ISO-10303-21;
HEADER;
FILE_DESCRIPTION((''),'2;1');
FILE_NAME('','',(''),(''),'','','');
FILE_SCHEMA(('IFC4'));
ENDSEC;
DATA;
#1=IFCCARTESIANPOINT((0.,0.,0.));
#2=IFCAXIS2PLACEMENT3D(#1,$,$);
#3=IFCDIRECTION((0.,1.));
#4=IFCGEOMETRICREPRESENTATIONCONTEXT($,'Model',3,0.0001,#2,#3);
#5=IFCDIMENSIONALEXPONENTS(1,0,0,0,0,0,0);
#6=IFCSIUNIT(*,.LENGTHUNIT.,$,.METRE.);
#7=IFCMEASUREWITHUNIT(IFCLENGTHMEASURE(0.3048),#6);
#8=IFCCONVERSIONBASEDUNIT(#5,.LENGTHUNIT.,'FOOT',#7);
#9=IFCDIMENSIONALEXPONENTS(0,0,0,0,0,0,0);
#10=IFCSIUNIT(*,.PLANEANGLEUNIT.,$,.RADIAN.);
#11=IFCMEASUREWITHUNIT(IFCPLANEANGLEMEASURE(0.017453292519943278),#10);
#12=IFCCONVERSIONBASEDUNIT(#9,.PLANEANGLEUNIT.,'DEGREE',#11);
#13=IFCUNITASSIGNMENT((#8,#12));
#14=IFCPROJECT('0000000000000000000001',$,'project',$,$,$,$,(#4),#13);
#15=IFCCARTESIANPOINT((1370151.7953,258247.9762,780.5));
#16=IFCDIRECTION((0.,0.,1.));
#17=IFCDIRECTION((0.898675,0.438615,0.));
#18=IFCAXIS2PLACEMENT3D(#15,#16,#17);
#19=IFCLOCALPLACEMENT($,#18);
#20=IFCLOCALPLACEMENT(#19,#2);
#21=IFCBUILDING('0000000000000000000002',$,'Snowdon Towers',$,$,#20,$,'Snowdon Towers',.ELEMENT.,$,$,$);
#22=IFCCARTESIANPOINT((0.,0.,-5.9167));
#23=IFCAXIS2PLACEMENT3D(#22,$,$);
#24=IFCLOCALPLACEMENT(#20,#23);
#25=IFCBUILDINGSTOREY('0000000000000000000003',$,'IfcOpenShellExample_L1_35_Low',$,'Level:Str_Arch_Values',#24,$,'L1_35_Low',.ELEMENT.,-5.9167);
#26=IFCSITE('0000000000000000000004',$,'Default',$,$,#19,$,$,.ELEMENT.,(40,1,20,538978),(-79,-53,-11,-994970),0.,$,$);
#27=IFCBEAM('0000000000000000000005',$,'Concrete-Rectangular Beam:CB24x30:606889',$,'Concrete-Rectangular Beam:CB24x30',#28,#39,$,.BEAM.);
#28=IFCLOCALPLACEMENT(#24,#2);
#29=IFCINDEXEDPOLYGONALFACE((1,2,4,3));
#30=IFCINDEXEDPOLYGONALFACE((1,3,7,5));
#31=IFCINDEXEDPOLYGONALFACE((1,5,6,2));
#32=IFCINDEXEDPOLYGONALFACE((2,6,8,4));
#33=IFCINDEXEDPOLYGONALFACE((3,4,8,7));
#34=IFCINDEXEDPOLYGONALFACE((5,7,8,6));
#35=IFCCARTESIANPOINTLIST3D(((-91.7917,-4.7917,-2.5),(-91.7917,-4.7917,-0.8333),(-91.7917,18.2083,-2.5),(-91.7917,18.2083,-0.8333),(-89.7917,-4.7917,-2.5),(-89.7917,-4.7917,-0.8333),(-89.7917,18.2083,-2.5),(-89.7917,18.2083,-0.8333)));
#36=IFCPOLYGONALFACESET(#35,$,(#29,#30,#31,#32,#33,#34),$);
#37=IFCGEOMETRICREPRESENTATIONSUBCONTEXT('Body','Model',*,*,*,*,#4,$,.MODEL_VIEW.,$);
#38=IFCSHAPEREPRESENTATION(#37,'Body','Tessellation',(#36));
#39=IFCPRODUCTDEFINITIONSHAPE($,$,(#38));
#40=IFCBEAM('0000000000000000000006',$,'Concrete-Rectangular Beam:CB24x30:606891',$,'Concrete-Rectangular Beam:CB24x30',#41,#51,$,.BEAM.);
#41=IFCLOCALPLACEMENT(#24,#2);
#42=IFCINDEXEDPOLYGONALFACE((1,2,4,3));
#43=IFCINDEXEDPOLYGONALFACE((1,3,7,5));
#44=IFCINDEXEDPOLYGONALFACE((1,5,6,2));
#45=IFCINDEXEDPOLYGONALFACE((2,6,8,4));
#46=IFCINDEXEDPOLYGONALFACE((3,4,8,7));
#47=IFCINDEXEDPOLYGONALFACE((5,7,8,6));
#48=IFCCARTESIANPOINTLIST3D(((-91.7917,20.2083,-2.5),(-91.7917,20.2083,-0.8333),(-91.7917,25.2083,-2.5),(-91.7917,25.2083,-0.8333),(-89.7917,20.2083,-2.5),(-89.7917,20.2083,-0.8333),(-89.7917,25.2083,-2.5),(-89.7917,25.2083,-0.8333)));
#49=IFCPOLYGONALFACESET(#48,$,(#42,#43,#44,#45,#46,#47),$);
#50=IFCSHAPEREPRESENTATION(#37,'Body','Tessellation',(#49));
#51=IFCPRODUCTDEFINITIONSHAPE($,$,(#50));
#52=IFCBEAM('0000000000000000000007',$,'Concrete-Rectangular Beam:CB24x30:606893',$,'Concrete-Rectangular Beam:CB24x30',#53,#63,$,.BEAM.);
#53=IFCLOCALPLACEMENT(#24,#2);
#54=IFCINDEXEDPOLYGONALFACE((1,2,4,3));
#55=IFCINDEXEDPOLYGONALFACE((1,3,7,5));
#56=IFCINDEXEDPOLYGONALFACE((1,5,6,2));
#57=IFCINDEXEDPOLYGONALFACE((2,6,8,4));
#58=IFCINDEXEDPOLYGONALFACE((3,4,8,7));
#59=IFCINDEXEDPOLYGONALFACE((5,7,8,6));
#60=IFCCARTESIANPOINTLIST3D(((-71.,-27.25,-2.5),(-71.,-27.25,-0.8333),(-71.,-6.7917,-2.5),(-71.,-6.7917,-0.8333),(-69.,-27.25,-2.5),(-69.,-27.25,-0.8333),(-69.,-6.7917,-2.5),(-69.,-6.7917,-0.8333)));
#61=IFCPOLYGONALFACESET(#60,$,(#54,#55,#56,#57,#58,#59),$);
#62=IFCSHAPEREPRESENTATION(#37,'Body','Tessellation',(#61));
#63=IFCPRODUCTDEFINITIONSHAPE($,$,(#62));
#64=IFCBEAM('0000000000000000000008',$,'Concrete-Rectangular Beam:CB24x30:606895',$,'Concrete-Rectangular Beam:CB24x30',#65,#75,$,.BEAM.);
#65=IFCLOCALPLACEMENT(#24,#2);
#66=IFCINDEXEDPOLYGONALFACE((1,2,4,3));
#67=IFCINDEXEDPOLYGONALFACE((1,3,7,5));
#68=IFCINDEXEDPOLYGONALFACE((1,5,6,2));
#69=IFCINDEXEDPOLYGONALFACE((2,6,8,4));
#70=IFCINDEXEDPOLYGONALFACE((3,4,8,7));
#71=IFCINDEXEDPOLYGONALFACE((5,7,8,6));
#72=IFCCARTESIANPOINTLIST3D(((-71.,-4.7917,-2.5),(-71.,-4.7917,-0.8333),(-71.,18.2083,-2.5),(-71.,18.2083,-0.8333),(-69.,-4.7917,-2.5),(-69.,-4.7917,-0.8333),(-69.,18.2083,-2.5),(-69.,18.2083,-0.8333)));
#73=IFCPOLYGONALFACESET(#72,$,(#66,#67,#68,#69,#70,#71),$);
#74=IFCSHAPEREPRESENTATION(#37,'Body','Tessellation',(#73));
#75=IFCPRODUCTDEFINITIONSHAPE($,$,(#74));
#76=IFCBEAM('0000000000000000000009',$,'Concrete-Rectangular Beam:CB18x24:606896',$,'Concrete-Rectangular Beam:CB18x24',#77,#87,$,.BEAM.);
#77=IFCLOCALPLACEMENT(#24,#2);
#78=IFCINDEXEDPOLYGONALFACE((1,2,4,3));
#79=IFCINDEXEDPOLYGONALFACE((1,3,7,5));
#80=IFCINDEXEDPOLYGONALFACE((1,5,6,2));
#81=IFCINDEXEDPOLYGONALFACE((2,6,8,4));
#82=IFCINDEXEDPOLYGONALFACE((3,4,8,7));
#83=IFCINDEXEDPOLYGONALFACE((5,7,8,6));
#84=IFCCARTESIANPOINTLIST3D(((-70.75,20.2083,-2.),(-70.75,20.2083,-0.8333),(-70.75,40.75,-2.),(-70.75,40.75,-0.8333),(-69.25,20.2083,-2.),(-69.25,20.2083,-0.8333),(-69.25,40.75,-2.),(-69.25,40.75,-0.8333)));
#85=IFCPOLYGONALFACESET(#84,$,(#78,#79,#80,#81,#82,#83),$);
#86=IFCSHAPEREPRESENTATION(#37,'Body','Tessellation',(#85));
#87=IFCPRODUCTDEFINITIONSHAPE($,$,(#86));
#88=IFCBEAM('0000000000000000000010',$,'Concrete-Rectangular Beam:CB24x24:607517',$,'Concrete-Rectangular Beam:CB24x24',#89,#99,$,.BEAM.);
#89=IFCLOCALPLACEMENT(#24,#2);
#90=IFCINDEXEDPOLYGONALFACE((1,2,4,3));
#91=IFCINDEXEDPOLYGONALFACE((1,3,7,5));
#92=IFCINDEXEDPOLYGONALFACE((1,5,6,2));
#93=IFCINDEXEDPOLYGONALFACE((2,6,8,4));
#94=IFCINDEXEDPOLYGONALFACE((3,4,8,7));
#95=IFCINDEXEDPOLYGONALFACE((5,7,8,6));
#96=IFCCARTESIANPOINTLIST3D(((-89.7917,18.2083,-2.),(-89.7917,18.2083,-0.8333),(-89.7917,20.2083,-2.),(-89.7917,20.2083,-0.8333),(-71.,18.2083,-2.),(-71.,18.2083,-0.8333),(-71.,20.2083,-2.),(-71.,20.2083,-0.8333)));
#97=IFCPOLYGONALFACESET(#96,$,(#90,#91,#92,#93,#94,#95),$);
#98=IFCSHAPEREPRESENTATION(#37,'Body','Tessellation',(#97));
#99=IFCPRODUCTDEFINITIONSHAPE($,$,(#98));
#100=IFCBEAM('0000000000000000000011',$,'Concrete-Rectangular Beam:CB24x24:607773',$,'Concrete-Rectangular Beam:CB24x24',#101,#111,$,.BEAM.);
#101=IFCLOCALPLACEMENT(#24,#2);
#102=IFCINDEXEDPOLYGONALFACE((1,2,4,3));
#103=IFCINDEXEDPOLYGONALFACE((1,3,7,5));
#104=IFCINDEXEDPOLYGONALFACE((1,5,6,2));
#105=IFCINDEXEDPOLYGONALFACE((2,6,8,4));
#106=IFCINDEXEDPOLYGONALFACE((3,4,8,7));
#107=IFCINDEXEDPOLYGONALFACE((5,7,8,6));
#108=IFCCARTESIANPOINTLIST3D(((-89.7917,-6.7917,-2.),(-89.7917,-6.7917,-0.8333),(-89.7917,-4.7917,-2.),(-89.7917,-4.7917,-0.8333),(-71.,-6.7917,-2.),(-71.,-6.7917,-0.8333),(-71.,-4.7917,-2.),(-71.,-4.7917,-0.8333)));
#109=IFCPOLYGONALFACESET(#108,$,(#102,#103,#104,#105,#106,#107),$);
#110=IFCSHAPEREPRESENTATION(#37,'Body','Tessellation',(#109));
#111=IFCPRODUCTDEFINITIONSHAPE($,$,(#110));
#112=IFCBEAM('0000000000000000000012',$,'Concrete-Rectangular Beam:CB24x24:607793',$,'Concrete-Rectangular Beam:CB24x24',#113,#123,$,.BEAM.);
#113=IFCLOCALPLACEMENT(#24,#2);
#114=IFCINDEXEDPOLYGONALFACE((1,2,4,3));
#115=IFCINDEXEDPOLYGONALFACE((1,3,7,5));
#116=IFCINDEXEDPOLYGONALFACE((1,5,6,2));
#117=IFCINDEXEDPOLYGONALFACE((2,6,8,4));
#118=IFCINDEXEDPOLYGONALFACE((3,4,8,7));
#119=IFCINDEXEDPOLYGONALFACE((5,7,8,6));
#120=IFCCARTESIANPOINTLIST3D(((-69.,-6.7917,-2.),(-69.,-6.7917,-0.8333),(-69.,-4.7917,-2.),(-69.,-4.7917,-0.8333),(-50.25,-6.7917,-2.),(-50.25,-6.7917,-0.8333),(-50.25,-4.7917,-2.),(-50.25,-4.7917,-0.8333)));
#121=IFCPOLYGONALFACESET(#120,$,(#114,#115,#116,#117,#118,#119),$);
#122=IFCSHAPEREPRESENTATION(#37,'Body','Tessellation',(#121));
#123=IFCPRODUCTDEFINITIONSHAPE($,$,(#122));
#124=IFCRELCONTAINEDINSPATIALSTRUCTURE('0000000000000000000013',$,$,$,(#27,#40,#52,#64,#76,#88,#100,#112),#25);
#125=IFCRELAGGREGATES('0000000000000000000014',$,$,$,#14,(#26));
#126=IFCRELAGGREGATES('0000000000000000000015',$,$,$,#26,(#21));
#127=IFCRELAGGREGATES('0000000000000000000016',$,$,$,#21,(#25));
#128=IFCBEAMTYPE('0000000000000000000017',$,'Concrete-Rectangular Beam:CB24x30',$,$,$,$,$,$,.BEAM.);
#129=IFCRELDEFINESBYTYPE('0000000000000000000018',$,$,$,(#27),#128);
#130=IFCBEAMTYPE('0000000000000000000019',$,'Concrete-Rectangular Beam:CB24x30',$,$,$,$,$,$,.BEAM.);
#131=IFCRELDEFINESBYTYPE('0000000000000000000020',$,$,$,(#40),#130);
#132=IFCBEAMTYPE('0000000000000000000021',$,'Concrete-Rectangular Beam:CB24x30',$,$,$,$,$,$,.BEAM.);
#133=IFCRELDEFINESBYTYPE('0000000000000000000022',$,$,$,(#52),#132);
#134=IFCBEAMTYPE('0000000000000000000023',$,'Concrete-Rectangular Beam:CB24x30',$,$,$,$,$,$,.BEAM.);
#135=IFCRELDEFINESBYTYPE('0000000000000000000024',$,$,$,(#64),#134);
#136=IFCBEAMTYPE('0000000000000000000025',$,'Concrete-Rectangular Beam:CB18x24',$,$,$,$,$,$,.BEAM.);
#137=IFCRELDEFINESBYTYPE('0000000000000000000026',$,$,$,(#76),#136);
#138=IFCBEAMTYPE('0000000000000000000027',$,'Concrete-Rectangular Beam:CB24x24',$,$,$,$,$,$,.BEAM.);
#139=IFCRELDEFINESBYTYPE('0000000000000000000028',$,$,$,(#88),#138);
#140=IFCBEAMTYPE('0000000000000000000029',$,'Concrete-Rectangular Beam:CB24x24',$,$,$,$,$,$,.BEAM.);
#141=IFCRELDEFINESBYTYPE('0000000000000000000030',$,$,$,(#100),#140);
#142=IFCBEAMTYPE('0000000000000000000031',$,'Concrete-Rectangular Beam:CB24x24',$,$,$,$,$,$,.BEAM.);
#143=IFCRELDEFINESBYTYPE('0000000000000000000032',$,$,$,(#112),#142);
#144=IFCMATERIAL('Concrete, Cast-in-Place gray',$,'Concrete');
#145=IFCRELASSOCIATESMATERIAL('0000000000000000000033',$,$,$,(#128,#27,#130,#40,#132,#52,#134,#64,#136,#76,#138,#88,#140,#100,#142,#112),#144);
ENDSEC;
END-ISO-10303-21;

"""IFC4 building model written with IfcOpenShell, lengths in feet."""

from ifc_helpers import new_model, entity, si_unit, converted_unit, direction, frame, origin, place, context, subcontext, project, spatial, indexed_curve, outline, extrude, source, transform, mapped, material, type_object, type_shapes, element, save


model = new_model("IFC4")

# Units and contexts
model_context = context("Model", 3, precision=0.0001, world=origin(), true_north=direction((0.0, 1.0)))
body_context = subcontext(model_context, "Body", "Model", "MODEL_VIEW")
ifc_project = project(units=[converted_unit("LENGTHUNIT", "FOOT", entity("IfcLengthMeasure", 0.3048), si_unit("LENGTHUNIT", "METRE"), dimensions=[1, 0, 0, 0, 0, 0, 0]), converted_unit("PLANEANGLEUNIT", "DEGREE", entity("IfcPlaneAngleMeasure", 0.017453292519943278), si_unit("PLANEANGLEUNIT", "RADIAN"), dimensions=[0, 0, 0, 0, 0, 0, 0])], contexts=[model_context])

# Site, building, storey
site_placement = place(None, frame((1370151.7953, 258247.9762, 780.5), z_axis=(0.0, 0.0, 1.0), x_axis=(0.898675, 0.438615, 0.0)))
site = spatial("IfcSite", under=ifc_project, at=site_placement, Name="Default", CompositionType="ELEMENT", RefLatitude=(40, 1, 20, 538978), RefLongitude=(-79, -53, -11, -994970), RefElevation=0.0)
building_placement = place(site_placement, origin())
building = spatial("IfcBuilding", under=site, at=building_placement, Name="Snowdon Towers", LongName="Snowdon Towers", CompositionType="ELEMENT")
storey_placement = place(building_placement, frame((0.0, 0.0, -5.9167)))
storey = spatial("IfcBuildingStorey", under=building, at=storey_placement, Name="IfcOpenShellExample_L1_35_Low", ObjectType="Level:Str_Arch_Values", LongName="L1_35_Low", CompositionType="ELEMENT", Elevation=-5.9167)

# Beams
ifc_material_1 = material(Name="Concrete, Cast-in-Place gray", Category="Concrete")
beam_type_1 = type_object("IfcBeamType", Name="Concrete-Rectangular Beam:CB24x30", PredefinedType="BEAM", material=ifc_material_1)
shared_shape_1 = source(origin(), body_context, "Body", "SweptSolid", [
    extrude(outline(indexed_curve([(-1.0, -0.8333), (1.0, -0.8333), (1.0, 0.8333), (-1.0, 0.8333), (-1.0, -0.8333)], self_intersect=False)), frame((-90.7917, -4.7917, -7.5833), z_axis=(0.0, 1.0, 0.0), x_axis=(-1.0, 0.0, 0.0)), (0.0, 0.0, 1.0), 23.0),
])
type_shapes(beam_type_1, [shared_shape_1])
beam_1_placement = place(storey_placement, frame((0.0, 0.0, 5.9167)))
element("IfcBeam", 1, at=beam_1_placement, inside=storey, type_object=beam_type_1, material=ifc_material_1, Name="Concrete-Rectangular Beam:CB24x30:606889", ObjectType="Concrete-Rectangular Beam:CB24x30", PredefinedType="BEAM", context=body_context, shape_type="MappedRepresentation", body=[
    mapped(shared_shape_1, transform((0.0, 0.0, 0.0), scale=1.0)),
])
beam_type_2 = type_object("IfcBeamType", Name="Concrete-Rectangular Beam:CB24x30", PredefinedType="BEAM", material=ifc_material_1)
shared_shape_2 = source(origin(), body_context, "Body", "SweptSolid", [
    extrude(outline(indexed_curve([(-1.0, -0.8333), (1.0, -0.8333), (1.0, 0.8333), (-1.0, 0.8333), (-1.0, -0.8333)], self_intersect=False)), frame((-90.7917, 20.2083, -7.5833), z_axis=(0.0, 1.0, 0.0), x_axis=(-1.0, 0.0, 0.0)), (0.0, 0.0, 1.0), 5.0),
])
type_shapes(beam_type_2, [shared_shape_2])
beam_2_placement = place(storey_placement, frame((0.0, 0.0, 5.9167)))
element("IfcBeam", 2, at=beam_2_placement, inside=storey, type_object=beam_type_2, material=ifc_material_1, Name="Concrete-Rectangular Beam:CB24x30:606891", ObjectType="Concrete-Rectangular Beam:CB24x30", PredefinedType="BEAM", context=body_context, shape_type="MappedRepresentation", body=[
    mapped(shared_shape_2, transform((0.0, 0.0, 0.0), scale=1.0)),
])
beam_type_3 = type_object("IfcBeamType", Name="Concrete-Rectangular Beam:CB24x30", PredefinedType="BEAM", material=ifc_material_1)
shared_shape_3 = source(origin(), body_context, "Body", "SweptSolid", [
    extrude(outline(indexed_curve([(-1.0, -0.8333), (1.0, -0.8333), (1.0, 0.8333), (-1.0, 0.8333), (-1.0, -0.8333)], self_intersect=False)), frame((-70.0, -27.25, -7.5833), z_axis=(0.0, 1.0, 0.0), x_axis=(-1.0, 0.0, 0.0)), (0.0, 0.0, 1.0), 20.4583),
])
type_shapes(beam_type_3, [shared_shape_3])
beam_3_placement = place(storey_placement, frame((0.0, 0.0, 5.9167)))
element("IfcBeam", 3, at=beam_3_placement, inside=storey, type_object=beam_type_3, material=ifc_material_1, Name="Concrete-Rectangular Beam:CB24x30:606893", ObjectType="Concrete-Rectangular Beam:CB24x30", PredefinedType="BEAM", context=body_context, shape_type="MappedRepresentation", body=[
    mapped(shared_shape_3, transform((0.0, 0.0, 0.0), scale=1.0)),
])
beam_type_4 = type_object("IfcBeamType", Name="Concrete-Rectangular Beam:CB24x30", PredefinedType="BEAM", material=ifc_material_1)
shared_shape_4 = source(origin(), body_context, "Body", "SweptSolid", [
    extrude(outline(indexed_curve([(-1.0, -0.8333), (1.0, -0.8333), (1.0, 0.8333), (-1.0, 0.8333), (-1.0, -0.8333)], self_intersect=False)), frame((-70.0, -4.7917, -7.5833), z_axis=(0.0, 1.0, 0.0), x_axis=(-1.0, 0.0, 0.0)), (0.0, 0.0, 1.0), 23.0),
])
type_shapes(beam_type_4, [shared_shape_4])
beam_4_placement = place(storey_placement, frame((0.0, 0.0, 5.9167)))
element("IfcBeam", 4, at=beam_4_placement, inside=storey, type_object=beam_type_4, material=ifc_material_1, Name="Concrete-Rectangular Beam:CB24x30:606895", ObjectType="Concrete-Rectangular Beam:CB24x30", PredefinedType="BEAM", context=body_context, shape_type="MappedRepresentation", body=[
    mapped(shared_shape_4, transform((0.0, 0.0, 0.0), scale=1.0)),
])
beam_type_5 = type_object("IfcBeamType", Name="Concrete-Rectangular Beam:CB18x24", PredefinedType="BEAM", material=ifc_material_1)
shared_shape_5 = source(origin(), body_context, "Body", "SweptSolid", [
    extrude(outline(indexed_curve([(-0.75, -0.5833), (0.75, -0.5833), (0.75, 0.5833), (-0.75, 0.5833), (-0.75, -0.5833)], self_intersect=False)), frame((-70.0, 20.2083, -7.3333), z_axis=(0.0, 1.0, 0.0), x_axis=(-1.0, 0.0, 0.0)), (0.0, 0.0, 1.0), 20.5417),
])
type_shapes(beam_type_5, [shared_shape_5])
beam_5_placement = place(storey_placement, frame((0.0, 0.0, 5.9167)))
element("IfcBeam", 5, at=beam_5_placement, inside=storey, type_object=beam_type_5, material=ifc_material_1, Name="Concrete-Rectangular Beam:CB18x24:606896", ObjectType="Concrete-Rectangular Beam:CB18x24", PredefinedType="BEAM", context=body_context, shape_type="MappedRepresentation", body=[
    mapped(shared_shape_5, transform((0.0, 0.0, 0.0), scale=1.0)),
])
beam_type_6 = type_object("IfcBeamType", Name="Concrete-Rectangular Beam:CB24x24", PredefinedType="BEAM", material=ifc_material_1)
shared_shape_6 = source(origin(), body_context, "Body", "SweptSolid", [
    extrude(outline(indexed_curve([(-0.5833, -1.0), (0.5833, -1.0), (0.5833, 1.0), (-0.5833, 1.0), (-0.5833, -1.0)], self_intersect=False)), frame((-89.7917, 19.2083, -7.3333), z_axis=(1.0, 0.0, 0.0), x_axis=(0.0, 0.0, -1.0)), (0.0, 0.0, 1.0), 18.7917),
])
type_shapes(beam_type_6, [shared_shape_6])
beam_6_placement = place(storey_placement, frame((0.0, 0.0, 5.9167)))
element("IfcBeam", 6, at=beam_6_placement, inside=storey, type_object=beam_type_6, material=ifc_material_1, Name="Concrete-Rectangular Beam:CB24x24:607517", ObjectType="Concrete-Rectangular Beam:CB24x24", PredefinedType="BEAM", context=body_context, shape_type="MappedRepresentation", body=[
    mapped(shared_shape_6, transform((0.0, 0.0, 0.0), scale=1.0)),
])
beam_type_7 = type_object("IfcBeamType", Name="Concrete-Rectangular Beam:CB24x24", PredefinedType="BEAM", material=ifc_material_1)
shared_shape_7 = source(origin(), body_context, "Body", "SweptSolid", [
    extrude(outline(indexed_curve([(-0.5833, -1.0), (0.5833, -1.0), (0.5833, 1.0), (-0.5833, 1.0), (-0.5833, -1.0)], self_intersect=False)), frame((-89.7917, -5.7917, -7.3333), z_axis=(1.0, 0.0, 0.0), x_axis=(0.0, 0.0, -1.0)), (0.0, 0.0, 1.0), 18.7917),
])
type_shapes(beam_type_7, [shared_shape_7])
beam_7_placement = place(storey_placement, frame((0.0, 0.0, 5.9167)))
element("IfcBeam", 7, at=beam_7_placement, inside=storey, type_object=beam_type_7, material=ifc_material_1, Name="Concrete-Rectangular Beam:CB24x24:607773", ObjectType="Concrete-Rectangular Beam:CB24x24", PredefinedType="BEAM", context=body_context, shape_type="MappedRepresentation", body=[
    mapped(shared_shape_7, transform((0.0, 0.0, 0.0), scale=1.0)),
])
beam_type_8 = type_object("IfcBeamType", Name="Concrete-Rectangular Beam:CB24x24", PredefinedType="BEAM", material=ifc_material_1)
shared_shape_8 = source(origin(), body_context, "Body", "SweptSolid", [
    extrude(outline(indexed_curve([(-0.5833, -1.0), (0.5833, -1.0), (0.5833, 1.0), (-0.5833, 1.0), (-0.5833, -1.0)], self_intersect=False)), frame((-69.0, -5.7917, -7.3333), z_axis=(1.0, 0.0, 0.0), x_axis=(0.0, 0.0, -1.0)), (0.0, 0.0, 1.0), 18.75),
])
type_shapes(beam_type_8, [shared_shape_8])
beam_8_placement = place(storey_placement, frame((0.0, 0.0, 5.9167)))
element("IfcBeam", 8, at=beam_8_placement, inside=storey, type_object=beam_type_8, material=ifc_material_1, Name="Concrete-Rectangular Beam:CB24x24:607793", ObjectType="Concrete-Rectangular Beam:CB24x24", PredefinedType="BEAM", context=body_context, shape_type="MappedRepresentation", body=[
    mapped(shared_shape_8, transform((0.0, 0.0, 0.0), scale=1.0)),
])

save(model, "model.ifc")
